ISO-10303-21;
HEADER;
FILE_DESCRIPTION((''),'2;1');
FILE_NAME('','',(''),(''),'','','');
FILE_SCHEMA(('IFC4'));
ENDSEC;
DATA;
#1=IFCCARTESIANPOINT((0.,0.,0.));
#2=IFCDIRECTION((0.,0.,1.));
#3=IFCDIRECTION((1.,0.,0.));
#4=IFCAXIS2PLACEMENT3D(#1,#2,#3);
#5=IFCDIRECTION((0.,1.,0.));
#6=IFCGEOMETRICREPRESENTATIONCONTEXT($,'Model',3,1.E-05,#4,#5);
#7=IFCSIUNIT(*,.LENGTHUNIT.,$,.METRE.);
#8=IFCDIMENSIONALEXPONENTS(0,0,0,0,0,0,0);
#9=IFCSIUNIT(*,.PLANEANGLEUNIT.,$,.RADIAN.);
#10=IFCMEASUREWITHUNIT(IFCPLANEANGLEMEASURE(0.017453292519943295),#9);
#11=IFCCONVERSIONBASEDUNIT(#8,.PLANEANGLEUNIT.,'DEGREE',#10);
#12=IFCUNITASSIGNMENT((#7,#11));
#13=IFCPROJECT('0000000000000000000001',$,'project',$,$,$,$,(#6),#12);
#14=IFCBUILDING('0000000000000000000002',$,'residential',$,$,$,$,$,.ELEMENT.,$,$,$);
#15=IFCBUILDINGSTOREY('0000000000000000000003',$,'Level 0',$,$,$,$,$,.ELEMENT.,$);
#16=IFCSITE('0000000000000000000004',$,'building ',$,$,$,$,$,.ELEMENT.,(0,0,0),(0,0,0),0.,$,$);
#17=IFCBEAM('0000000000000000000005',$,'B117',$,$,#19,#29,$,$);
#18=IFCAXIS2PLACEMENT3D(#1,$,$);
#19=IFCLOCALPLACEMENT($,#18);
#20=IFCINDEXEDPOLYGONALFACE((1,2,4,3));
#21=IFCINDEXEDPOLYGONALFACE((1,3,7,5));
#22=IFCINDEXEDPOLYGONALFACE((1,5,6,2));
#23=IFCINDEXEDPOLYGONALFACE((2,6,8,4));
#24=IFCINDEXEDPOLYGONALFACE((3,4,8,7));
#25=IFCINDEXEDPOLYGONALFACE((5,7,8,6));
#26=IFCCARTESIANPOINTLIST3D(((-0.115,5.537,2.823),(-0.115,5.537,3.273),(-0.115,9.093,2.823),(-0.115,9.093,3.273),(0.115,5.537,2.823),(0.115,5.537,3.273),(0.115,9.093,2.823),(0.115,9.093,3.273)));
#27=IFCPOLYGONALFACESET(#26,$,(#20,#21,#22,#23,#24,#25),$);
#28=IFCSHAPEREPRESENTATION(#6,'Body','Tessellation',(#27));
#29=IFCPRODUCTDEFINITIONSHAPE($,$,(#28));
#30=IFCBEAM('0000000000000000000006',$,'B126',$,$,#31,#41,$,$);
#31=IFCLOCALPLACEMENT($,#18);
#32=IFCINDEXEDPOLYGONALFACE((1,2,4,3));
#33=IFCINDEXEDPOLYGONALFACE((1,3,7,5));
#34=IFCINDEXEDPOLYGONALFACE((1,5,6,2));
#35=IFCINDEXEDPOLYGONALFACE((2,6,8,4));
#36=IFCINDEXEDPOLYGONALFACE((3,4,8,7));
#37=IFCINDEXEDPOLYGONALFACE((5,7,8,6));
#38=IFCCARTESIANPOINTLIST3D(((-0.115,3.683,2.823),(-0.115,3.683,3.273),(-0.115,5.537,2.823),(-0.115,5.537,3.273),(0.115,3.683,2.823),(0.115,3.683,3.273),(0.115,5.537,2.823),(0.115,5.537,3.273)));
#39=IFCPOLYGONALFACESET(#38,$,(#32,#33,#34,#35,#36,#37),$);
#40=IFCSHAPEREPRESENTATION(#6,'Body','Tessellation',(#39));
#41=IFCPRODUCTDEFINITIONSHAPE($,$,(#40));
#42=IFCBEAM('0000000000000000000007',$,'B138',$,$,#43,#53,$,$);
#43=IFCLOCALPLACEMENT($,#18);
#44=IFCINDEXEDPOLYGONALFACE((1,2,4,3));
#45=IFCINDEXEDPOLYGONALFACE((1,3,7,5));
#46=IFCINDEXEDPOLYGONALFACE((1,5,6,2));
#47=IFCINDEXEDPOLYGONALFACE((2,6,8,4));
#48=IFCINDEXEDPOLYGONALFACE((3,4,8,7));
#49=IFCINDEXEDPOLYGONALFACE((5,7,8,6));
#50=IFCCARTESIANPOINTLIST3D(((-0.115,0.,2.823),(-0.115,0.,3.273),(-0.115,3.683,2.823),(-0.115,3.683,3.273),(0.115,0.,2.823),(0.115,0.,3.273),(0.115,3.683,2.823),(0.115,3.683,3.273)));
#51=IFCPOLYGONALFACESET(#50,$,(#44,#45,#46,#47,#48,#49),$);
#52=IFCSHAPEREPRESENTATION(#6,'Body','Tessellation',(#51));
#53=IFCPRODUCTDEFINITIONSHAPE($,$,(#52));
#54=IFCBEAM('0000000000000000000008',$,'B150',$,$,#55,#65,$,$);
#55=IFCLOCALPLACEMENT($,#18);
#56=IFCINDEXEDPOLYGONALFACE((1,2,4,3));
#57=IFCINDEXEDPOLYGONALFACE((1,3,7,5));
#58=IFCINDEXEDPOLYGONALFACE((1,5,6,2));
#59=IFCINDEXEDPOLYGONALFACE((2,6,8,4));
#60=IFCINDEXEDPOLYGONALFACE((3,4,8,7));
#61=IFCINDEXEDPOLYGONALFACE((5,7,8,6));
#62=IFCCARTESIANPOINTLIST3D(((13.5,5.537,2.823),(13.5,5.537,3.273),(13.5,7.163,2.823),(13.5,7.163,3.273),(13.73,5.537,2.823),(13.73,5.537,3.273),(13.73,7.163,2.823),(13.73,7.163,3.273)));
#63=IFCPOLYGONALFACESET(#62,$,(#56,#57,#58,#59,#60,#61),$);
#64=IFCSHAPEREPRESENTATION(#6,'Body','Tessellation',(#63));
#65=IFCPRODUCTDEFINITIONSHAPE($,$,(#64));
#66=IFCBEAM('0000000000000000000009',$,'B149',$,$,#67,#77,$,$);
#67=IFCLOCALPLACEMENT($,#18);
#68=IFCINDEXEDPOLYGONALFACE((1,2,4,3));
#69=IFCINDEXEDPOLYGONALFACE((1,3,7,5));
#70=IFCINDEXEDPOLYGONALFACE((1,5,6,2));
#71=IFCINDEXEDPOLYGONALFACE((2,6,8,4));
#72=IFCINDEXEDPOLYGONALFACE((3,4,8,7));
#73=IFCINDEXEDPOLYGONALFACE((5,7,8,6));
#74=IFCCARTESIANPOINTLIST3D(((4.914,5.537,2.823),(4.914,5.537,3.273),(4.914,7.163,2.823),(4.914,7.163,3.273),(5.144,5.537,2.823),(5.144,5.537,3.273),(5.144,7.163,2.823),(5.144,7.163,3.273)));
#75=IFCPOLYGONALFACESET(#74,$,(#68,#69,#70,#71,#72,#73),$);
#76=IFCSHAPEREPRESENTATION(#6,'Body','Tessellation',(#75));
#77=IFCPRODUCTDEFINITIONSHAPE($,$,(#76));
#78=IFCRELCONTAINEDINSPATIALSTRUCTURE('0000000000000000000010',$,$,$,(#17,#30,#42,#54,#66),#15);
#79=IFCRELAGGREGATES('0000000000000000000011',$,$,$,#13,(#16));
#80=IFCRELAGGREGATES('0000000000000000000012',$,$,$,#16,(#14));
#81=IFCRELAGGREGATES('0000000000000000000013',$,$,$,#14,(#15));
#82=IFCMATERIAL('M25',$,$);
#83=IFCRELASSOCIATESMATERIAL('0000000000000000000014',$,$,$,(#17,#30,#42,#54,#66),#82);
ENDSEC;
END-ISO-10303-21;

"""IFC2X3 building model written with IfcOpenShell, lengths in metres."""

from ifc_helpers import new_model, entity, si_unit, converted_unit, direction, frame, frame_2d, origin_with_axes, place, context, project, spatial, rectangle, extrude, material, element, save


model = new_model("IFC2X3")

# Units and contexts
model_context = context("Model", 3, precision=1e-05, world=origin_with_axes(), true_north=direction((0.0, 1.0, 0.0)))
ifc_project = project(units=[si_unit("LENGTHUNIT", "METRE"), converted_unit("PLANEANGLEUNIT", "DEGREE", entity("IfcPlaneAngleMeasure", 0.017453292519943295), si_unit("PLANEANGLEUNIT", "RADIAN"), dimensions=[0, 0, 0, 0, 0, 0, 0])], contexts=[model_context])

# Site, building, storey
site = spatial("IfcSite", under=ifc_project, Name="building ", CompositionType="ELEMENT", RefLatitude=(0, 0, 0), RefLongitude=(0, 0, 0), RefElevation=0.0)
building = spatial("IfcBuilding", under=site, Name="residential", CompositionType="ELEMENT")
storey = spatial("IfcBuildingStorey", under=building, Name="Level 0", CompositionType="ELEMENT")

# Beams
ifc_material = material(Name="M25")
placement = place(None, origin_with_axes())
element("IfcBeam", 1, at=placement, inside=storey, material=ifc_material, Name="B117", context=model_context, shape_type="SweptSolid", body=[
    extrude(rectangle(XDim=0.23, YDim=0.45, at=frame_2d((0.0, 0.0), x_axis=(0.0, 1.0, 0.0))), frame((0.0, 5.537, 3.048), z_axis=(0.0, 1.0, 0.0), x_axis=(0.0, 0.0, -1.0)), (0.0, 0.0, 1.0), 3.556),
])
element("IfcBeam", 2, at=placement, inside=storey, material=ifc_material, Name="B126", context=model_context, shape_type="SweptSolid", body=[
    extrude(rectangle(XDim=0.23, YDim=0.45, at=frame_2d((0.0, 0.0), x_axis=(0.0, 1.0, 0.0))), frame((0.0, 3.683, 3.048), z_axis=(0.0, 1.0, 0.0), x_axis=(0.0, 0.0, -1.0)), (0.0, 0.0, 1.0), 1.854),
])
element("IfcBeam", 3, at=placement, inside=storey, material=ifc_material, Name="B138", context=model_context, shape_type="SweptSolid", body=[
    extrude(rectangle(XDim=0.23, YDim=0.45, at=frame_2d((0.0, 0.0), x_axis=(0.0, 1.0, 0.0))), frame((0.0, 0.0, 3.048), z_axis=(0.0, 1.0, 0.0), x_axis=(0.0, 0.0, -1.0)), (0.0, 0.0, 1.0), 3.683),
])
element("IfcBeam", 4, at=placement, inside=storey, material=ifc_material, Name="B150", context=model_context, shape_type="SweptSolid", body=[
    extrude(rectangle(XDim=0.23, YDim=0.45, at=frame_2d((0.0, 0.0), x_axis=(0.0, 1.0, 0.0))), frame((13.615, 5.537, 3.048), z_axis=(0.0, 1.0, 0.0), x_axis=(0.0, 0.0, -1.0)), (0.0, 0.0, 1.0), 1.626),
])
element("IfcBeam", 5, at=placement, inside=storey, material=ifc_material, Name="B149", context=model_context, shape_type="SweptSolid", body=[
    extrude(rectangle(XDim=0.23, YDim=0.45, at=frame_2d((0.0, 0.0), x_axis=(0.0, 1.0, 0.0))), frame((5.029, 5.537, 3.048), z_axis=(0.0, 1.0, 0.0), x_axis=(0.0, 0.0, -1.0)), (0.0, 0.0, 1.0), 1.626),
])

save(model, "model.ifc")
